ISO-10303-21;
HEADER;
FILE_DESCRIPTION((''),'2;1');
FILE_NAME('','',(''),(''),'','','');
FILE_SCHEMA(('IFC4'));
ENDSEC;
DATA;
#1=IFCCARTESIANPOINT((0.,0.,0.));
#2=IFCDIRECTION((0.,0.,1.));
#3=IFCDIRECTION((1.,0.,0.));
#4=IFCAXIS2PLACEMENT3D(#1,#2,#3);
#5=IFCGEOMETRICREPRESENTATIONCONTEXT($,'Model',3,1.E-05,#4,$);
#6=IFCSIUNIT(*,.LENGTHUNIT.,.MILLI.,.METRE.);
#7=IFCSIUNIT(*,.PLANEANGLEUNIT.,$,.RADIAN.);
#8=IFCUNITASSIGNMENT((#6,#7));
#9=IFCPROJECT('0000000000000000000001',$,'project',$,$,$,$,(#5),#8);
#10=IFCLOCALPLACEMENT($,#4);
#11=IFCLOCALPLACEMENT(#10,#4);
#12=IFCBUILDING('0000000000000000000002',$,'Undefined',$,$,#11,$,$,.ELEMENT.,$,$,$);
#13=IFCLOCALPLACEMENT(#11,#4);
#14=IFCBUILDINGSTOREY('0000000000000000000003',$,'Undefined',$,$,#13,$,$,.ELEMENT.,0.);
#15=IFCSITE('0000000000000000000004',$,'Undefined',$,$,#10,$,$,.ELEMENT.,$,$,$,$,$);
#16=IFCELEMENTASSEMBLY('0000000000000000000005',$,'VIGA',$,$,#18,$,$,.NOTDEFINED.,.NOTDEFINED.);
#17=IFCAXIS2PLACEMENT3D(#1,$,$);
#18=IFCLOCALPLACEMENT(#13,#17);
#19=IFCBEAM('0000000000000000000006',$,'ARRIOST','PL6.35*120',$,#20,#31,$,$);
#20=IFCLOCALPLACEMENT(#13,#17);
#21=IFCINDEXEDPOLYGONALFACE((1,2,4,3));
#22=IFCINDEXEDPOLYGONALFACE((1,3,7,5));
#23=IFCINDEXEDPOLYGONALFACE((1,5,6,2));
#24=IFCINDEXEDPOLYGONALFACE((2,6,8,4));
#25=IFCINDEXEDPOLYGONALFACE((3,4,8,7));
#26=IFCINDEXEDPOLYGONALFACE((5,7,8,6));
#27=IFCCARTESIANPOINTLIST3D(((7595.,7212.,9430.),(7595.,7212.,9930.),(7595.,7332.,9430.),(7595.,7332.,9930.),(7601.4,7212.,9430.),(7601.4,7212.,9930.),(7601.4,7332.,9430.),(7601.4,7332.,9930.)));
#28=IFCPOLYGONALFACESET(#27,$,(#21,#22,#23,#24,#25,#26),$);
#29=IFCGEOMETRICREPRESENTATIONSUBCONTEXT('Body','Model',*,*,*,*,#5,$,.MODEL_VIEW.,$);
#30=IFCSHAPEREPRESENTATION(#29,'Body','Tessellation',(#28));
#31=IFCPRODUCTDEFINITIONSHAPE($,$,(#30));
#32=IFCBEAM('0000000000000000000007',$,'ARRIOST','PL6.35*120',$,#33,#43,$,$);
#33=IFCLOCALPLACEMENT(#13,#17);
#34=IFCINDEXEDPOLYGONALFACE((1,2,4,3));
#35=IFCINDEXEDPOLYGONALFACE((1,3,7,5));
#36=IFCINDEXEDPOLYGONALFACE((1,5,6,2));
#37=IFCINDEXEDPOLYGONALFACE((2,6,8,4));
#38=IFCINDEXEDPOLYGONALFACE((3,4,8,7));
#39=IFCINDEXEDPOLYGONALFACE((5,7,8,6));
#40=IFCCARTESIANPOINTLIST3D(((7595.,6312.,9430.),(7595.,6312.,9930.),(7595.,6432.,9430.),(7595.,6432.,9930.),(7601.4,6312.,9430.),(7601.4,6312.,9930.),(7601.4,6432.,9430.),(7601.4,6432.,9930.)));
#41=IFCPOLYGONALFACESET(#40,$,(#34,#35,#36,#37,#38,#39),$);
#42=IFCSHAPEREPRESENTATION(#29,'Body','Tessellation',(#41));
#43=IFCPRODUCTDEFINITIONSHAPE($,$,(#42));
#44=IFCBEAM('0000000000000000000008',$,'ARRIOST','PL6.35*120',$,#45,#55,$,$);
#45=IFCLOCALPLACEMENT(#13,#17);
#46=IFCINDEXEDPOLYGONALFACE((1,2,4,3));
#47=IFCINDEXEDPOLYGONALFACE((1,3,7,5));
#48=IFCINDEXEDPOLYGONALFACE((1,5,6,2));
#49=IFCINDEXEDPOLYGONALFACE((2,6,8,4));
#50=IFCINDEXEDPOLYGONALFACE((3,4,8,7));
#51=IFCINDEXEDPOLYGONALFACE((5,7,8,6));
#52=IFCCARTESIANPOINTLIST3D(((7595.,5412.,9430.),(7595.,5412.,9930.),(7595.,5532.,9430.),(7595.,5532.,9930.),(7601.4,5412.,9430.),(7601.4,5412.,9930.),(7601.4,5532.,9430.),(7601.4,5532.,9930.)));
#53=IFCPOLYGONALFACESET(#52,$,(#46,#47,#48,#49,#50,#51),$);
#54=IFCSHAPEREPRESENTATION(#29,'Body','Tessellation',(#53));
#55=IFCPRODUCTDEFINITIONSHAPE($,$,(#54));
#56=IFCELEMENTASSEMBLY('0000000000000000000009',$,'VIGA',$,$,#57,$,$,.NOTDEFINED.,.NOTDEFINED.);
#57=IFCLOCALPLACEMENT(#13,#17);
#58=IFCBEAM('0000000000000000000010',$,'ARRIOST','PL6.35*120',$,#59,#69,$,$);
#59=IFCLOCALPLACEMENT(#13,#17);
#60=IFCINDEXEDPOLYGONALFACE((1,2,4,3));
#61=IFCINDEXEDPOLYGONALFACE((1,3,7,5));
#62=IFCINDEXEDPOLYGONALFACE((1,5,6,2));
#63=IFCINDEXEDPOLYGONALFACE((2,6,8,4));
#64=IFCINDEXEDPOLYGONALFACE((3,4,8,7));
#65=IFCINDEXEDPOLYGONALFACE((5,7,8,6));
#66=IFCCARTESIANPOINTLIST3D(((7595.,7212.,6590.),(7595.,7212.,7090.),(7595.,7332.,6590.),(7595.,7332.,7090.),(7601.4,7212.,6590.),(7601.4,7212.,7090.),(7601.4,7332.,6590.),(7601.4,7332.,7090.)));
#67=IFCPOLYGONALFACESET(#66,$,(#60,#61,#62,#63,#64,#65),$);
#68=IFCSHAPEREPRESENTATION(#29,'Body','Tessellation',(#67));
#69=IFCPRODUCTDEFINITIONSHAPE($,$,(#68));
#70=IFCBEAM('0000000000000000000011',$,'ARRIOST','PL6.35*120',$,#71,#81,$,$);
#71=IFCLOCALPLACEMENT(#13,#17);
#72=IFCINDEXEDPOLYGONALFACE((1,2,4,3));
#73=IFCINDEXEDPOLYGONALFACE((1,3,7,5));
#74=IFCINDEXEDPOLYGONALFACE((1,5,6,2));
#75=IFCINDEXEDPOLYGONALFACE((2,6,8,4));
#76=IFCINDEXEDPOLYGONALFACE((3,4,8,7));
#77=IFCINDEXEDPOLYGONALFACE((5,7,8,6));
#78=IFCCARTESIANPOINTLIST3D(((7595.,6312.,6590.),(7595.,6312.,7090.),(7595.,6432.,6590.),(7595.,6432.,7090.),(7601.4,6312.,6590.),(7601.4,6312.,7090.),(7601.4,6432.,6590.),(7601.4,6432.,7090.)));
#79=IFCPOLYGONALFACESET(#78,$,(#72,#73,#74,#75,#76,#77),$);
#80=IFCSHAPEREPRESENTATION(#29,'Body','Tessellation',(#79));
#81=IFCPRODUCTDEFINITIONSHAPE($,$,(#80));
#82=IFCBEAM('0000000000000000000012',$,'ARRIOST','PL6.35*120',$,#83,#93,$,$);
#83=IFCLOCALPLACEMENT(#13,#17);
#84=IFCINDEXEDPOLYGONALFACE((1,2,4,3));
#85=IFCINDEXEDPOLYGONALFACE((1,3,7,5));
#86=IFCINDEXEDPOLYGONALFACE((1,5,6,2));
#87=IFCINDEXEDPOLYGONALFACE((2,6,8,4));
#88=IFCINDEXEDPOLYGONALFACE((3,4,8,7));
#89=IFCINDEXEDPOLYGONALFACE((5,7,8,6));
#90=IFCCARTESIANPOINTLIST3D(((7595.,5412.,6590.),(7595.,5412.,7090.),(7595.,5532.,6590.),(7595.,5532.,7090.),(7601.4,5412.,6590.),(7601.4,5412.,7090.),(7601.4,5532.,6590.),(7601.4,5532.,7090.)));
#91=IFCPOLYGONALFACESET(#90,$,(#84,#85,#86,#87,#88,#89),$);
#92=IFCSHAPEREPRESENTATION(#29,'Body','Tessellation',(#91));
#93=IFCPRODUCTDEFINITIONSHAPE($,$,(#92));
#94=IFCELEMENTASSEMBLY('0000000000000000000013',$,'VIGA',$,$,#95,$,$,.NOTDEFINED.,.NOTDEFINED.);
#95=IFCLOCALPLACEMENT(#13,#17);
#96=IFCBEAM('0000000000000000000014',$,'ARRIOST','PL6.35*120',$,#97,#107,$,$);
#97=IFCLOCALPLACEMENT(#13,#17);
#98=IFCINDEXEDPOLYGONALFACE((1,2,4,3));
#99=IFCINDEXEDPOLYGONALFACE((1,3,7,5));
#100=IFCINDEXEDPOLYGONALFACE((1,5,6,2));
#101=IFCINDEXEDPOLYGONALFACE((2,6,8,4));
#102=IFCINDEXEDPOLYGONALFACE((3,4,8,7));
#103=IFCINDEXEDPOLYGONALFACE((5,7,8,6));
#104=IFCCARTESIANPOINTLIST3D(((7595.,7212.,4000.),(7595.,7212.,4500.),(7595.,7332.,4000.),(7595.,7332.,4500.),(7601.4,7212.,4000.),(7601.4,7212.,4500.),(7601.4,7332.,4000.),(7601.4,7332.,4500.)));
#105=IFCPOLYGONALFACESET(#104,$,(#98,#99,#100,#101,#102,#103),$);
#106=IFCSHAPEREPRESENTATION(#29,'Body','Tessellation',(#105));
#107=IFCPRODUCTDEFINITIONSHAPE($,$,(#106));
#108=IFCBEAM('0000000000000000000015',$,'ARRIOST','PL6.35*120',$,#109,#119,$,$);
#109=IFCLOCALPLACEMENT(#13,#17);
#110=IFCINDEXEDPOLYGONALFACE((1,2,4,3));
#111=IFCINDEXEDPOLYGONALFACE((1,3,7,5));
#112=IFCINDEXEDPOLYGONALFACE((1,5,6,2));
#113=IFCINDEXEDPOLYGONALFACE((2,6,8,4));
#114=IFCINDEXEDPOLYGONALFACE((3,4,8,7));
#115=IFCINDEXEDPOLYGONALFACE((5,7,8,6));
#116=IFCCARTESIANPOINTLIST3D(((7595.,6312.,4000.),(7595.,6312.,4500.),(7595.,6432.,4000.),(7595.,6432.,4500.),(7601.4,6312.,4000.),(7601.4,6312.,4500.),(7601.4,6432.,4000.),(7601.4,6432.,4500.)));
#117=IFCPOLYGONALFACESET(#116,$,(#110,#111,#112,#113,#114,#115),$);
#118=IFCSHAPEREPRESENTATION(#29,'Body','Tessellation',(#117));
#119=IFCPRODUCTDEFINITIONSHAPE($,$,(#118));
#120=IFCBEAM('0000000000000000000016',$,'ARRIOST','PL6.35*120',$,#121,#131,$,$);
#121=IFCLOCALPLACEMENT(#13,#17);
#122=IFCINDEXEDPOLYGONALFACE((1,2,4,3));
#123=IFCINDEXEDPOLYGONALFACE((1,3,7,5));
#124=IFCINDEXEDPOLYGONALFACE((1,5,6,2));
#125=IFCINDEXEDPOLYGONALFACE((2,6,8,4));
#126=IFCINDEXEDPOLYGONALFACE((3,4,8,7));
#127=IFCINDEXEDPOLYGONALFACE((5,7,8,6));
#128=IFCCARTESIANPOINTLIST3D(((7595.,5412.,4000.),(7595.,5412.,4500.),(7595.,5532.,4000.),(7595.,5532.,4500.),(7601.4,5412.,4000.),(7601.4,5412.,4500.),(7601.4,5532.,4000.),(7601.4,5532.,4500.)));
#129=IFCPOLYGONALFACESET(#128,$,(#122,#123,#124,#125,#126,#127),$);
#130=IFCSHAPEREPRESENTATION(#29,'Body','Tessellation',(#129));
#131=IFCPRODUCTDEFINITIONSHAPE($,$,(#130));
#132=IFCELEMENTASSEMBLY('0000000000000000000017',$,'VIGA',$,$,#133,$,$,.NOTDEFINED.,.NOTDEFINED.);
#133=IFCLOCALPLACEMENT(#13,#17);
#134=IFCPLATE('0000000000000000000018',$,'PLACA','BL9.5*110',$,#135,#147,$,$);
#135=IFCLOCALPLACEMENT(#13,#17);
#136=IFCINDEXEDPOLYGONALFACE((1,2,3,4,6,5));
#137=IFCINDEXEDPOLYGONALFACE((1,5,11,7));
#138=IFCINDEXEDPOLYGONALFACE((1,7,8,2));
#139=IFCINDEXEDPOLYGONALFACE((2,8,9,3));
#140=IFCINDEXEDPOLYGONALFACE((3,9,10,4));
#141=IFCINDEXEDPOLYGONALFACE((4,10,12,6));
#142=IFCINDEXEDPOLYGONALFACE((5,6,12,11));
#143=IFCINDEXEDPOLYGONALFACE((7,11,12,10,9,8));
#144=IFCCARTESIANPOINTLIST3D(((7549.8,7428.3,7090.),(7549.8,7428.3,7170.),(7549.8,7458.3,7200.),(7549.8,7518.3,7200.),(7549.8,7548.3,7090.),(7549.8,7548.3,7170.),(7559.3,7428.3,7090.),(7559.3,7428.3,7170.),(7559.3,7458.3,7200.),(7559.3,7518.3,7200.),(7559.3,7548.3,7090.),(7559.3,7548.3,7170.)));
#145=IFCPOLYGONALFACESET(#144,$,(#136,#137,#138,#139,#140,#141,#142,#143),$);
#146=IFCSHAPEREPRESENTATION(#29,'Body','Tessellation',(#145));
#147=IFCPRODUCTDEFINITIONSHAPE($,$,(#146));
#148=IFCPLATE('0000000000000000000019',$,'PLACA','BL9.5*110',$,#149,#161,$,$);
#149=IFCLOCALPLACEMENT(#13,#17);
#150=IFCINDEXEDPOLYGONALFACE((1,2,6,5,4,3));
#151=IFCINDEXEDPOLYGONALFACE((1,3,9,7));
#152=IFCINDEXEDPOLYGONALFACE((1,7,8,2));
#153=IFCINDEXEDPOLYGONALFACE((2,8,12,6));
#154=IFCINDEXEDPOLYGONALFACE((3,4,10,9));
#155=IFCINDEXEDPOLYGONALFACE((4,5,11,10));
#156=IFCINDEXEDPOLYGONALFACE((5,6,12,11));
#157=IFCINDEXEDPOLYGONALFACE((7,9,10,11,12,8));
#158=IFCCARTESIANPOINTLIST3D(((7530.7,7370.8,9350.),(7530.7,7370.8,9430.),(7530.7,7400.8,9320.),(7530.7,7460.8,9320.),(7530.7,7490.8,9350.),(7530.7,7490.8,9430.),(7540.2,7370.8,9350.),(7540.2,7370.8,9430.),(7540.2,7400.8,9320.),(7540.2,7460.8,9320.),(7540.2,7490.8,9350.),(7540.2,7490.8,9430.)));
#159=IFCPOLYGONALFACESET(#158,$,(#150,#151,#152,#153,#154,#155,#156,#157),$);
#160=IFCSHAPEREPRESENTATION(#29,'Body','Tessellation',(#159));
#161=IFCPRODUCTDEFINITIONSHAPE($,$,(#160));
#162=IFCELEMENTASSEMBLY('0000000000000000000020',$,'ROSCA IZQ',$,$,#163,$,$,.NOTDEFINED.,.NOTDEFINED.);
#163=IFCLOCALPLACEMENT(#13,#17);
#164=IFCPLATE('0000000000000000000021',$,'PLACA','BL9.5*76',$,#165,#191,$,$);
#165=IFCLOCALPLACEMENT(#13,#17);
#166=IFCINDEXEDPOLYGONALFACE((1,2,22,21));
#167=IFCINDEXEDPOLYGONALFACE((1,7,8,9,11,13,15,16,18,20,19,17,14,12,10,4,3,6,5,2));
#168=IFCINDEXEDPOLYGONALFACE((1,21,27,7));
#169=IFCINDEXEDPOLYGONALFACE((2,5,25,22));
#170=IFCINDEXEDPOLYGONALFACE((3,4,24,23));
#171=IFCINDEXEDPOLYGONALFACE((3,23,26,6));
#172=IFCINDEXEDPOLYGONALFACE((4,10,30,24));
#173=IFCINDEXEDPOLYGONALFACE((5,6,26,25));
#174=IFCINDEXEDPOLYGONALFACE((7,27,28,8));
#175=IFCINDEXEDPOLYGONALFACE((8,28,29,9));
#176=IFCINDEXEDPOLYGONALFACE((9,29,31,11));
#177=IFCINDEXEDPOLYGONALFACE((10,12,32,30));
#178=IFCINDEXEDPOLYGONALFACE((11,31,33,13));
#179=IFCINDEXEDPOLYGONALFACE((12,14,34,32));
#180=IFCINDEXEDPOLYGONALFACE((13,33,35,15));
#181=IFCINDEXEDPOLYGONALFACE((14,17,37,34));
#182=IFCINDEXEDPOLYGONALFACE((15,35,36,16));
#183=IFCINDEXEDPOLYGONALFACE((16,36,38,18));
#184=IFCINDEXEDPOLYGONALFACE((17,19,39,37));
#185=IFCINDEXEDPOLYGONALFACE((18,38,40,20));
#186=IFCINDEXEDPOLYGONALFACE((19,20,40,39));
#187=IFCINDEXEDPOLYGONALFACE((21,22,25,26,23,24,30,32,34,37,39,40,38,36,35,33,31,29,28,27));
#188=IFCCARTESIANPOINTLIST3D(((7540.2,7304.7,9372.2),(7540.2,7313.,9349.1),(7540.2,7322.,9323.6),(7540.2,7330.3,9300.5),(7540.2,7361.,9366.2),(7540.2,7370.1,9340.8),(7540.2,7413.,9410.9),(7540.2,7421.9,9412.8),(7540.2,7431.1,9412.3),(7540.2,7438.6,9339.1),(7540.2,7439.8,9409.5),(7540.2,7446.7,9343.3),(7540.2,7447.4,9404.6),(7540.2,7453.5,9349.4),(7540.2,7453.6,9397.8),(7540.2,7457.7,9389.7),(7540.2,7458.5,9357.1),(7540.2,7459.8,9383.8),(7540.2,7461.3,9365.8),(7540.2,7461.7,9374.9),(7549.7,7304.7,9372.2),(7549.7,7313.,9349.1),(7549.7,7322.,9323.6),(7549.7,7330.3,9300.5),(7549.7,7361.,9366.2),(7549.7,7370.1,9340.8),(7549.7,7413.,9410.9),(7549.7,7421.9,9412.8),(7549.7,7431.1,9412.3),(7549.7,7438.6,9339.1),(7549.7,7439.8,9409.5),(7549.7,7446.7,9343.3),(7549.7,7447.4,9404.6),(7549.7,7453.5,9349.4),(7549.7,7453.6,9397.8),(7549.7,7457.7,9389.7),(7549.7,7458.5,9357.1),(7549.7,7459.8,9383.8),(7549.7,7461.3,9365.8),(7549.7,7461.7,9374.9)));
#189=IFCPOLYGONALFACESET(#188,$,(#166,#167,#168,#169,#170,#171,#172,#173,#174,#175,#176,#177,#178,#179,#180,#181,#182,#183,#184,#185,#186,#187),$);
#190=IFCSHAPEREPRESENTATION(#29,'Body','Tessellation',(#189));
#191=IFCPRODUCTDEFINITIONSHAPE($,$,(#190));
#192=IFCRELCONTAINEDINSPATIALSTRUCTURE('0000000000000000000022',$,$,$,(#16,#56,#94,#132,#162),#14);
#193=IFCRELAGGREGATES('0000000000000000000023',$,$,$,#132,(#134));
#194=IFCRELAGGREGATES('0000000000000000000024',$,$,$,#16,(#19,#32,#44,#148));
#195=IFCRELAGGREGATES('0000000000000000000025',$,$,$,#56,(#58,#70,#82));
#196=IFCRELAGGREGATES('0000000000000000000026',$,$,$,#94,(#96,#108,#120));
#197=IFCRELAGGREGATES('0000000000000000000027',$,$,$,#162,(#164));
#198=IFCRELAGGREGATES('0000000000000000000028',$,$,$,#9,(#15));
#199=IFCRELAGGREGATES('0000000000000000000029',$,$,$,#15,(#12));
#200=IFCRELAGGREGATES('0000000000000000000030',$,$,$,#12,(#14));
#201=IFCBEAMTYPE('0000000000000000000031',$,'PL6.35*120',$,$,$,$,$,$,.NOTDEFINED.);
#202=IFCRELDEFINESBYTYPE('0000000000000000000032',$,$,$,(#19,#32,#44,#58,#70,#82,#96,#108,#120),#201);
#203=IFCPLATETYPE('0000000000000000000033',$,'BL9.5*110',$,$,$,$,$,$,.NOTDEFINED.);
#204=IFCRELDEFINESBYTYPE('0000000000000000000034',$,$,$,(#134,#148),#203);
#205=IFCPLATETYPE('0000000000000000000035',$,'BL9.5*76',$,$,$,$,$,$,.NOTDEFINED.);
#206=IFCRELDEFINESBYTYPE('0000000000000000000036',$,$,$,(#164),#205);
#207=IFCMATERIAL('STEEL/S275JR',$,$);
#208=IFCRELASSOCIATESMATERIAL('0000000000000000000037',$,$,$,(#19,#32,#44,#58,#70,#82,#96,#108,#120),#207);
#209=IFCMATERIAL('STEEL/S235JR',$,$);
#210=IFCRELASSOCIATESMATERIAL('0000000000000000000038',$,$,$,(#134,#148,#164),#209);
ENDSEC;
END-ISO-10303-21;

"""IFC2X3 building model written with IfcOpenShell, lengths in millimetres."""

from ifc_helpers import new_model, si_unit, frame, frame_2d, origin_with_axes, origin_2d_with_axis, place, context, subcontext, project, spatial, polyline, circle_curve, parameter, trimmed, segment, composite_curve, rectangle, outline, extrude, boolean, material, type_object, element, aggregate, save


model = new_model("IFC2X3")

# Units and contexts
model_context = context("Model", 3, precision=1e-05, world=origin_with_axes())
body_context = subcontext(model_context, "Body", "Model", "MODEL_VIEW")
ifc_project = project(units=[si_unit("LENGTHUNIT", "METRE", prefix="MILLI"), si_unit("PLANEANGLEUNIT", "RADIAN")], contexts=[model_context])

# Site, building, storey
site_placement = place(None, origin_with_axes())
site = spatial("IfcSite", under=ifc_project, at=site_placement, Name="Undefined", CompositionType="ELEMENT")
building_placement = place(site_placement, origin_with_axes())
building = spatial("IfcBuilding", under=site, at=building_placement, Name="Undefined", CompositionType="ELEMENT")
storey_placement = place(building_placement, origin_with_axes())
storey = spatial("IfcBuildingStorey", under=building, at=storey_placement, Name="Undefined", CompositionType="ELEMENT", Elevation=0.0)

# Element assemblies, beams
assembly_1_placement = place(storey_placement, origin_with_axes())
assembly_1 = element("IfcElementAssembly", 1, at=assembly_1_placement, inside=storey, Name="VIGA", AssemblyPlace="NOTDEFINED", PredefinedType="NOTDEFINED")
ifc_material_1 = material(Name="STEEL/S275JR")
beam_type = type_object("IfcBeamType", Name="PL6.35*120", PredefinedType="NOTDEFINED")
beam_1_placement = place(assembly_1_placement, frame((7598.2, 7272.0, 9430.0), z_axis=(0.0, 1.0, 0.0), x_axis=(0.0, 0.0, 1.0)))
beam_1 = element("IfcBeam", 2, at=beam_1_placement, type_object=beam_type, material=ifc_material_1, Name="ARRIOST", Description="PL6.35*120", context=body_context, shape_type="SweptSolid", body=[
    extrude(rectangle(XDim=6.3, YDim=120.0, at=origin_2d_with_axis()), frame((500.0, 0.0, 0.0), z_axis=(-1.0, 0.0, 0.0), x_axis=(0.0, -1.0, 0.0)), (0.0, 0.0, 1.0), 500.0),
])
beam_2_placement = place(assembly_1_placement, frame((7598.2, 6372.0, 9430.0), z_axis=(0.0, 1.0, 0.0), x_axis=(0.0, 0.0, 1.0)))
beam_2 = element("IfcBeam", 3, at=beam_2_placement, type_object=beam_type, material=ifc_material_1, Name="ARRIOST", Description="PL6.35*120", context=body_context, shape_type="SweptSolid", body=[
    extrude(rectangle(XDim=6.3, YDim=120.0, at=origin_2d_with_axis()), frame((500.0, 0.0, 0.0), z_axis=(-1.0, 0.0, 0.0), x_axis=(0.0, -1.0, 0.0)), (0.0, 0.0, 1.0), 500.0),
])
beam_3_placement = place(assembly_1_placement, frame((7598.2, 5472.0, 9430.0), z_axis=(0.0, 1.0, 0.0), x_axis=(0.0, 0.0, 1.0)))
beam_3 = element("IfcBeam", 4, at=beam_3_placement, type_object=beam_type, material=ifc_material_1, Name="ARRIOST", Description="PL6.35*120", context=body_context, shape_type="SweptSolid", body=[
    extrude(rectangle(XDim=6.3, YDim=120.0, at=origin_2d_with_axis()), frame((500.0, 0.0, 0.0), z_axis=(-1.0, 0.0, 0.0), x_axis=(0.0, -1.0, 0.0)), (0.0, 0.0, 1.0), 500.0),
])
assembly_2_placement = place(storey_placement, origin_with_axes())
assembly_2 = element("IfcElementAssembly", 5, at=assembly_2_placement, inside=storey, Name="VIGA", AssemblyPlace="NOTDEFINED", PredefinedType="NOTDEFINED")
beam_4_placement = place(assembly_2_placement, frame((7598.2, 7272.0, 6590.0), z_axis=(0.0, 1.0, 0.0), x_axis=(0.0, 0.0, 1.0)))
beam_4 = element("IfcBeam", 6, at=beam_4_placement, type_object=beam_type, material=ifc_material_1, Name="ARRIOST", Description="PL6.35*120", context=body_context, shape_type="SweptSolid", body=[
    extrude(rectangle(XDim=6.3, YDim=120.0, at=origin_2d_with_axis()), frame((500.0, 0.0, 0.0), z_axis=(-1.0, 0.0, 0.0), x_axis=(0.0, -1.0, 0.0)), (0.0, 0.0, 1.0), 500.0),
])
beam_5_placement = place(assembly_2_placement, frame((7598.2, 6372.0, 6590.0), z_axis=(0.0, 1.0, 0.0), x_axis=(0.0, 0.0, 1.0)))
beam_5 = element("IfcBeam", 7, at=beam_5_placement, type_object=beam_type, material=ifc_material_1, Name="ARRIOST", Description="PL6.35*120", context=body_context, shape_type="SweptSolid", body=[
    extrude(rectangle(XDim=6.3, YDim=120.0, at=origin_2d_with_axis()), frame((500.0, 0.0, 0.0), z_axis=(-1.0, 0.0, 0.0), x_axis=(0.0, -1.0, 0.0)), (0.0, 0.0, 1.0), 500.0),
])
beam_6_placement = place(assembly_2_placement, frame((7598.2, 5472.0, 6590.0), z_axis=(0.0, 1.0, 0.0), x_axis=(0.0, 0.0, 1.0)))
beam_6 = element("IfcBeam", 8, at=beam_6_placement, type_object=beam_type, material=ifc_material_1, Name="ARRIOST", Description="PL6.35*120", context=body_context, shape_type="SweptSolid", body=[
    extrude(rectangle(XDim=6.3, YDim=120.0, at=origin_2d_with_axis()), frame((500.0, 0.0, 0.0), z_axis=(-1.0, 0.0, 0.0), x_axis=(0.0, -1.0, 0.0)), (0.0, 0.0, 1.0), 500.0),
])
assembly_3_placement = place(storey_placement, origin_with_axes())
assembly_3 = element("IfcElementAssembly", 9, at=assembly_3_placement, inside=storey, Name="VIGA", AssemblyPlace="NOTDEFINED", PredefinedType="NOTDEFINED")
beam_7_placement = place(assembly_3_placement, frame((7598.2, 7272.0, 4000.0), z_axis=(0.0, 1.0, 0.0), x_axis=(0.0, 0.0, 1.0)))
beam_7 = element("IfcBeam", 10, at=beam_7_placement, type_object=beam_type, material=ifc_material_1, Name="ARRIOST", Description="PL6.35*120", context=body_context, shape_type="SweptSolid", body=[
    extrude(rectangle(XDim=6.3, YDim=120.0, at=origin_2d_with_axis()), frame((500.0, 0.0, 0.0), z_axis=(-1.0, 0.0, 0.0), x_axis=(0.0, -1.0, 0.0)), (0.0, 0.0, 1.0), 500.0),
])
beam_8_placement = place(assembly_3_placement, frame((7598.2, 6372.0, 4000.0), z_axis=(0.0, 1.0, 0.0), x_axis=(0.0, 0.0, 1.0)))
beam_8 = element("IfcBeam", 11, at=beam_8_placement, type_object=beam_type, material=ifc_material_1, Name="ARRIOST", Description="PL6.35*120", context=body_context, shape_type="SweptSolid", body=[
    extrude(rectangle(XDim=6.3, YDim=120.0, at=origin_2d_with_axis()), frame((500.0, 0.0, 0.0), z_axis=(-1.0, 0.0, 0.0), x_axis=(0.0, -1.0, 0.0)), (0.0, 0.0, 1.0), 500.0),
])
beam_9_placement = place(assembly_3_placement, frame((7598.2, 5472.0, 4000.0), z_axis=(0.0, 1.0, 0.0), x_axis=(0.0, 0.0, 1.0)))
beam_9 = element("IfcBeam", 12, at=beam_9_placement, type_object=beam_type, material=ifc_material_1, Name="ARRIOST", Description="PL6.35*120", context=body_context, shape_type="SweptSolid", body=[
    extrude(rectangle(XDim=6.3, YDim=120.0, at=origin_2d_with_axis()), frame((500.0, 0.0, 0.0), z_axis=(-1.0, 0.0, 0.0), x_axis=(0.0, -1.0, 0.0)), (0.0, 0.0, 1.0), 500.0),
])

# Element assembly, plate
assembly_4_placement = place(storey_placement, origin_with_axes())
assembly_4 = element("IfcElementAssembly", 13, at=assembly_4_placement, inside=storey, Name="VIGA", AssemblyPlace="NOTDEFINED", PredefinedType="NOTDEFINED")
ifc_material_2 = material(Name="STEEL/S235JR")
plate_type_1 = type_object("IfcPlateType", Name="BL9.5*110", PredefinedType="NOTDEFINED")
plate_1_placement = place(assembly_4_placement, frame((7554.5, 7428.3, 7090.0), z_axis=(-1.0, 0.0, 0.0), x_axis=(0.0, 0.0, 1.0)))
plate_1 = element("IfcPlate", 14, at=plate_1_placement, type_object=plate_type_1, material=ifc_material_2, Name="PLACA", Description="BL9.5*110", context=body_context, shape_type="SweptSolid", body=[
    extrude(outline(polyline([(0.0, 0.0), (80.0, 0.0), (110.0, 30.0), (110.0, 90.0), (80.0, 120.0), (0.0, 120.0), (0.0, 0.0)])), frame((0.0, 0.0, -4.7), z_axis=(0.0, 0.0, 1.0), x_axis=(1.0, 0.0, 0.0)), (0.0, 0.0, 1.0), 9.5),
])
aggregate(assembly_4, [plate_1])

# Plate
plate_2_placement = place(assembly_1_placement, frame((7535.5, 7370.8, 9430.0), z_axis=(1.0, 0.0, 0.0), x_axis=(0.0, 0.0, -1.0)))
plate_2 = element("IfcPlate", 15, at=plate_2_placement, type_object=plate_type_1, material=ifc_material_2, Name="PLACA", Description="BL9.5*110", context=body_context, shape_type="SweptSolid", body=[
    extrude(outline(polyline([(0.0, 0.0), (80.0, 0.0), (110.0, 30.0), (110.0, 90.0), (80.0, 120.0), (0.0, 120.0), (0.0, 0.0)])), frame((0.0, 0.0, -4.7), z_axis=(0.0, 0.0, 1.0), x_axis=(1.0, 0.0, 0.0)), (0.0, 0.0, 1.0), 9.5),
])
aggregate(assembly_1, [beam_1, beam_2, beam_3, plate_2])

# Element assembly, plate
assembly_5_placement = place(storey_placement, origin_with_axes())
assembly_5 = element("IfcElementAssembly", 16, at=assembly_5_placement, inside=storey, Name="ROSCA IZQ", AssemblyPlace="NOTDEFINED", PredefinedType="NOTDEFINED")
plate_type_2 = type_object("IfcPlateType", Name="BL9.5*76", PredefinedType="NOTDEFINED")
plate_3_placement = place(assembly_5_placement, frame((7545.0, 7471.6, 9350.9), z_axis=(1.0, 0.0, 0.0), x_axis=(0.0, -0.335983, 0.941868)))
plate_3 = element("IfcPlate", 17, at=plate_3_placement, type_object=plate_type_2, material=ifc_material_2, Name="PLACA", Description="BL9.5*76", context=body_context, shape_type="CSG", body=[
    boolean("DIFFERENCE", extrude(outline(composite_curve([segment(trimmed(circle_curve(frame_2d((35.0, 35.0), x_axis=(-1.0, 0.0)), 35.0), [parameter(0.0)], [parameter(1.570796)], True, "PARAMETER"), True, "CONTINUOUS"), segment(polyline([(35.0, 0.0), (41.2, 0.0)]), True, "CONTINUOUS"), segment(trimmed(circle_curve(frame_2d((41.2, 35.0), x_axis=(0.0, -1.0)), 35.0), [parameter(0.0)], [parameter(1.570796)], True, "PARAMETER"), True, "CONTINUOUS"), segment(polyline([(76.2, 35.0), (76.2, 150.0), (0.0, 150.0), (0.0, 35.0)]), True, "CONTINUOUS")], self_intersect=True)), frame((0.0, 0.0, -4.7), z_axis=(0.0, 0.0, 1.0), x_axis=(1.0, 0.0, 0.0)), (0.0, 0.0, 1.0), 9.5), extrude(rectangle(XDim=27.0, YDim=27.0, at=origin_2d_with_axis()), frame((38.1, 250.0, 0.0), z_axis=(0.0, -1.0, 0.0), x_axis=(0.0, 0.0, 1.0)), (0.0, 0.0, 1.0), 151.0)),
])

aggregate(assembly_2, [beam_4, beam_5, beam_6])

aggregate(assembly_3, [beam_7, beam_8, beam_9])

aggregate(assembly_5, [plate_3])

save(model, "model.ifc")
